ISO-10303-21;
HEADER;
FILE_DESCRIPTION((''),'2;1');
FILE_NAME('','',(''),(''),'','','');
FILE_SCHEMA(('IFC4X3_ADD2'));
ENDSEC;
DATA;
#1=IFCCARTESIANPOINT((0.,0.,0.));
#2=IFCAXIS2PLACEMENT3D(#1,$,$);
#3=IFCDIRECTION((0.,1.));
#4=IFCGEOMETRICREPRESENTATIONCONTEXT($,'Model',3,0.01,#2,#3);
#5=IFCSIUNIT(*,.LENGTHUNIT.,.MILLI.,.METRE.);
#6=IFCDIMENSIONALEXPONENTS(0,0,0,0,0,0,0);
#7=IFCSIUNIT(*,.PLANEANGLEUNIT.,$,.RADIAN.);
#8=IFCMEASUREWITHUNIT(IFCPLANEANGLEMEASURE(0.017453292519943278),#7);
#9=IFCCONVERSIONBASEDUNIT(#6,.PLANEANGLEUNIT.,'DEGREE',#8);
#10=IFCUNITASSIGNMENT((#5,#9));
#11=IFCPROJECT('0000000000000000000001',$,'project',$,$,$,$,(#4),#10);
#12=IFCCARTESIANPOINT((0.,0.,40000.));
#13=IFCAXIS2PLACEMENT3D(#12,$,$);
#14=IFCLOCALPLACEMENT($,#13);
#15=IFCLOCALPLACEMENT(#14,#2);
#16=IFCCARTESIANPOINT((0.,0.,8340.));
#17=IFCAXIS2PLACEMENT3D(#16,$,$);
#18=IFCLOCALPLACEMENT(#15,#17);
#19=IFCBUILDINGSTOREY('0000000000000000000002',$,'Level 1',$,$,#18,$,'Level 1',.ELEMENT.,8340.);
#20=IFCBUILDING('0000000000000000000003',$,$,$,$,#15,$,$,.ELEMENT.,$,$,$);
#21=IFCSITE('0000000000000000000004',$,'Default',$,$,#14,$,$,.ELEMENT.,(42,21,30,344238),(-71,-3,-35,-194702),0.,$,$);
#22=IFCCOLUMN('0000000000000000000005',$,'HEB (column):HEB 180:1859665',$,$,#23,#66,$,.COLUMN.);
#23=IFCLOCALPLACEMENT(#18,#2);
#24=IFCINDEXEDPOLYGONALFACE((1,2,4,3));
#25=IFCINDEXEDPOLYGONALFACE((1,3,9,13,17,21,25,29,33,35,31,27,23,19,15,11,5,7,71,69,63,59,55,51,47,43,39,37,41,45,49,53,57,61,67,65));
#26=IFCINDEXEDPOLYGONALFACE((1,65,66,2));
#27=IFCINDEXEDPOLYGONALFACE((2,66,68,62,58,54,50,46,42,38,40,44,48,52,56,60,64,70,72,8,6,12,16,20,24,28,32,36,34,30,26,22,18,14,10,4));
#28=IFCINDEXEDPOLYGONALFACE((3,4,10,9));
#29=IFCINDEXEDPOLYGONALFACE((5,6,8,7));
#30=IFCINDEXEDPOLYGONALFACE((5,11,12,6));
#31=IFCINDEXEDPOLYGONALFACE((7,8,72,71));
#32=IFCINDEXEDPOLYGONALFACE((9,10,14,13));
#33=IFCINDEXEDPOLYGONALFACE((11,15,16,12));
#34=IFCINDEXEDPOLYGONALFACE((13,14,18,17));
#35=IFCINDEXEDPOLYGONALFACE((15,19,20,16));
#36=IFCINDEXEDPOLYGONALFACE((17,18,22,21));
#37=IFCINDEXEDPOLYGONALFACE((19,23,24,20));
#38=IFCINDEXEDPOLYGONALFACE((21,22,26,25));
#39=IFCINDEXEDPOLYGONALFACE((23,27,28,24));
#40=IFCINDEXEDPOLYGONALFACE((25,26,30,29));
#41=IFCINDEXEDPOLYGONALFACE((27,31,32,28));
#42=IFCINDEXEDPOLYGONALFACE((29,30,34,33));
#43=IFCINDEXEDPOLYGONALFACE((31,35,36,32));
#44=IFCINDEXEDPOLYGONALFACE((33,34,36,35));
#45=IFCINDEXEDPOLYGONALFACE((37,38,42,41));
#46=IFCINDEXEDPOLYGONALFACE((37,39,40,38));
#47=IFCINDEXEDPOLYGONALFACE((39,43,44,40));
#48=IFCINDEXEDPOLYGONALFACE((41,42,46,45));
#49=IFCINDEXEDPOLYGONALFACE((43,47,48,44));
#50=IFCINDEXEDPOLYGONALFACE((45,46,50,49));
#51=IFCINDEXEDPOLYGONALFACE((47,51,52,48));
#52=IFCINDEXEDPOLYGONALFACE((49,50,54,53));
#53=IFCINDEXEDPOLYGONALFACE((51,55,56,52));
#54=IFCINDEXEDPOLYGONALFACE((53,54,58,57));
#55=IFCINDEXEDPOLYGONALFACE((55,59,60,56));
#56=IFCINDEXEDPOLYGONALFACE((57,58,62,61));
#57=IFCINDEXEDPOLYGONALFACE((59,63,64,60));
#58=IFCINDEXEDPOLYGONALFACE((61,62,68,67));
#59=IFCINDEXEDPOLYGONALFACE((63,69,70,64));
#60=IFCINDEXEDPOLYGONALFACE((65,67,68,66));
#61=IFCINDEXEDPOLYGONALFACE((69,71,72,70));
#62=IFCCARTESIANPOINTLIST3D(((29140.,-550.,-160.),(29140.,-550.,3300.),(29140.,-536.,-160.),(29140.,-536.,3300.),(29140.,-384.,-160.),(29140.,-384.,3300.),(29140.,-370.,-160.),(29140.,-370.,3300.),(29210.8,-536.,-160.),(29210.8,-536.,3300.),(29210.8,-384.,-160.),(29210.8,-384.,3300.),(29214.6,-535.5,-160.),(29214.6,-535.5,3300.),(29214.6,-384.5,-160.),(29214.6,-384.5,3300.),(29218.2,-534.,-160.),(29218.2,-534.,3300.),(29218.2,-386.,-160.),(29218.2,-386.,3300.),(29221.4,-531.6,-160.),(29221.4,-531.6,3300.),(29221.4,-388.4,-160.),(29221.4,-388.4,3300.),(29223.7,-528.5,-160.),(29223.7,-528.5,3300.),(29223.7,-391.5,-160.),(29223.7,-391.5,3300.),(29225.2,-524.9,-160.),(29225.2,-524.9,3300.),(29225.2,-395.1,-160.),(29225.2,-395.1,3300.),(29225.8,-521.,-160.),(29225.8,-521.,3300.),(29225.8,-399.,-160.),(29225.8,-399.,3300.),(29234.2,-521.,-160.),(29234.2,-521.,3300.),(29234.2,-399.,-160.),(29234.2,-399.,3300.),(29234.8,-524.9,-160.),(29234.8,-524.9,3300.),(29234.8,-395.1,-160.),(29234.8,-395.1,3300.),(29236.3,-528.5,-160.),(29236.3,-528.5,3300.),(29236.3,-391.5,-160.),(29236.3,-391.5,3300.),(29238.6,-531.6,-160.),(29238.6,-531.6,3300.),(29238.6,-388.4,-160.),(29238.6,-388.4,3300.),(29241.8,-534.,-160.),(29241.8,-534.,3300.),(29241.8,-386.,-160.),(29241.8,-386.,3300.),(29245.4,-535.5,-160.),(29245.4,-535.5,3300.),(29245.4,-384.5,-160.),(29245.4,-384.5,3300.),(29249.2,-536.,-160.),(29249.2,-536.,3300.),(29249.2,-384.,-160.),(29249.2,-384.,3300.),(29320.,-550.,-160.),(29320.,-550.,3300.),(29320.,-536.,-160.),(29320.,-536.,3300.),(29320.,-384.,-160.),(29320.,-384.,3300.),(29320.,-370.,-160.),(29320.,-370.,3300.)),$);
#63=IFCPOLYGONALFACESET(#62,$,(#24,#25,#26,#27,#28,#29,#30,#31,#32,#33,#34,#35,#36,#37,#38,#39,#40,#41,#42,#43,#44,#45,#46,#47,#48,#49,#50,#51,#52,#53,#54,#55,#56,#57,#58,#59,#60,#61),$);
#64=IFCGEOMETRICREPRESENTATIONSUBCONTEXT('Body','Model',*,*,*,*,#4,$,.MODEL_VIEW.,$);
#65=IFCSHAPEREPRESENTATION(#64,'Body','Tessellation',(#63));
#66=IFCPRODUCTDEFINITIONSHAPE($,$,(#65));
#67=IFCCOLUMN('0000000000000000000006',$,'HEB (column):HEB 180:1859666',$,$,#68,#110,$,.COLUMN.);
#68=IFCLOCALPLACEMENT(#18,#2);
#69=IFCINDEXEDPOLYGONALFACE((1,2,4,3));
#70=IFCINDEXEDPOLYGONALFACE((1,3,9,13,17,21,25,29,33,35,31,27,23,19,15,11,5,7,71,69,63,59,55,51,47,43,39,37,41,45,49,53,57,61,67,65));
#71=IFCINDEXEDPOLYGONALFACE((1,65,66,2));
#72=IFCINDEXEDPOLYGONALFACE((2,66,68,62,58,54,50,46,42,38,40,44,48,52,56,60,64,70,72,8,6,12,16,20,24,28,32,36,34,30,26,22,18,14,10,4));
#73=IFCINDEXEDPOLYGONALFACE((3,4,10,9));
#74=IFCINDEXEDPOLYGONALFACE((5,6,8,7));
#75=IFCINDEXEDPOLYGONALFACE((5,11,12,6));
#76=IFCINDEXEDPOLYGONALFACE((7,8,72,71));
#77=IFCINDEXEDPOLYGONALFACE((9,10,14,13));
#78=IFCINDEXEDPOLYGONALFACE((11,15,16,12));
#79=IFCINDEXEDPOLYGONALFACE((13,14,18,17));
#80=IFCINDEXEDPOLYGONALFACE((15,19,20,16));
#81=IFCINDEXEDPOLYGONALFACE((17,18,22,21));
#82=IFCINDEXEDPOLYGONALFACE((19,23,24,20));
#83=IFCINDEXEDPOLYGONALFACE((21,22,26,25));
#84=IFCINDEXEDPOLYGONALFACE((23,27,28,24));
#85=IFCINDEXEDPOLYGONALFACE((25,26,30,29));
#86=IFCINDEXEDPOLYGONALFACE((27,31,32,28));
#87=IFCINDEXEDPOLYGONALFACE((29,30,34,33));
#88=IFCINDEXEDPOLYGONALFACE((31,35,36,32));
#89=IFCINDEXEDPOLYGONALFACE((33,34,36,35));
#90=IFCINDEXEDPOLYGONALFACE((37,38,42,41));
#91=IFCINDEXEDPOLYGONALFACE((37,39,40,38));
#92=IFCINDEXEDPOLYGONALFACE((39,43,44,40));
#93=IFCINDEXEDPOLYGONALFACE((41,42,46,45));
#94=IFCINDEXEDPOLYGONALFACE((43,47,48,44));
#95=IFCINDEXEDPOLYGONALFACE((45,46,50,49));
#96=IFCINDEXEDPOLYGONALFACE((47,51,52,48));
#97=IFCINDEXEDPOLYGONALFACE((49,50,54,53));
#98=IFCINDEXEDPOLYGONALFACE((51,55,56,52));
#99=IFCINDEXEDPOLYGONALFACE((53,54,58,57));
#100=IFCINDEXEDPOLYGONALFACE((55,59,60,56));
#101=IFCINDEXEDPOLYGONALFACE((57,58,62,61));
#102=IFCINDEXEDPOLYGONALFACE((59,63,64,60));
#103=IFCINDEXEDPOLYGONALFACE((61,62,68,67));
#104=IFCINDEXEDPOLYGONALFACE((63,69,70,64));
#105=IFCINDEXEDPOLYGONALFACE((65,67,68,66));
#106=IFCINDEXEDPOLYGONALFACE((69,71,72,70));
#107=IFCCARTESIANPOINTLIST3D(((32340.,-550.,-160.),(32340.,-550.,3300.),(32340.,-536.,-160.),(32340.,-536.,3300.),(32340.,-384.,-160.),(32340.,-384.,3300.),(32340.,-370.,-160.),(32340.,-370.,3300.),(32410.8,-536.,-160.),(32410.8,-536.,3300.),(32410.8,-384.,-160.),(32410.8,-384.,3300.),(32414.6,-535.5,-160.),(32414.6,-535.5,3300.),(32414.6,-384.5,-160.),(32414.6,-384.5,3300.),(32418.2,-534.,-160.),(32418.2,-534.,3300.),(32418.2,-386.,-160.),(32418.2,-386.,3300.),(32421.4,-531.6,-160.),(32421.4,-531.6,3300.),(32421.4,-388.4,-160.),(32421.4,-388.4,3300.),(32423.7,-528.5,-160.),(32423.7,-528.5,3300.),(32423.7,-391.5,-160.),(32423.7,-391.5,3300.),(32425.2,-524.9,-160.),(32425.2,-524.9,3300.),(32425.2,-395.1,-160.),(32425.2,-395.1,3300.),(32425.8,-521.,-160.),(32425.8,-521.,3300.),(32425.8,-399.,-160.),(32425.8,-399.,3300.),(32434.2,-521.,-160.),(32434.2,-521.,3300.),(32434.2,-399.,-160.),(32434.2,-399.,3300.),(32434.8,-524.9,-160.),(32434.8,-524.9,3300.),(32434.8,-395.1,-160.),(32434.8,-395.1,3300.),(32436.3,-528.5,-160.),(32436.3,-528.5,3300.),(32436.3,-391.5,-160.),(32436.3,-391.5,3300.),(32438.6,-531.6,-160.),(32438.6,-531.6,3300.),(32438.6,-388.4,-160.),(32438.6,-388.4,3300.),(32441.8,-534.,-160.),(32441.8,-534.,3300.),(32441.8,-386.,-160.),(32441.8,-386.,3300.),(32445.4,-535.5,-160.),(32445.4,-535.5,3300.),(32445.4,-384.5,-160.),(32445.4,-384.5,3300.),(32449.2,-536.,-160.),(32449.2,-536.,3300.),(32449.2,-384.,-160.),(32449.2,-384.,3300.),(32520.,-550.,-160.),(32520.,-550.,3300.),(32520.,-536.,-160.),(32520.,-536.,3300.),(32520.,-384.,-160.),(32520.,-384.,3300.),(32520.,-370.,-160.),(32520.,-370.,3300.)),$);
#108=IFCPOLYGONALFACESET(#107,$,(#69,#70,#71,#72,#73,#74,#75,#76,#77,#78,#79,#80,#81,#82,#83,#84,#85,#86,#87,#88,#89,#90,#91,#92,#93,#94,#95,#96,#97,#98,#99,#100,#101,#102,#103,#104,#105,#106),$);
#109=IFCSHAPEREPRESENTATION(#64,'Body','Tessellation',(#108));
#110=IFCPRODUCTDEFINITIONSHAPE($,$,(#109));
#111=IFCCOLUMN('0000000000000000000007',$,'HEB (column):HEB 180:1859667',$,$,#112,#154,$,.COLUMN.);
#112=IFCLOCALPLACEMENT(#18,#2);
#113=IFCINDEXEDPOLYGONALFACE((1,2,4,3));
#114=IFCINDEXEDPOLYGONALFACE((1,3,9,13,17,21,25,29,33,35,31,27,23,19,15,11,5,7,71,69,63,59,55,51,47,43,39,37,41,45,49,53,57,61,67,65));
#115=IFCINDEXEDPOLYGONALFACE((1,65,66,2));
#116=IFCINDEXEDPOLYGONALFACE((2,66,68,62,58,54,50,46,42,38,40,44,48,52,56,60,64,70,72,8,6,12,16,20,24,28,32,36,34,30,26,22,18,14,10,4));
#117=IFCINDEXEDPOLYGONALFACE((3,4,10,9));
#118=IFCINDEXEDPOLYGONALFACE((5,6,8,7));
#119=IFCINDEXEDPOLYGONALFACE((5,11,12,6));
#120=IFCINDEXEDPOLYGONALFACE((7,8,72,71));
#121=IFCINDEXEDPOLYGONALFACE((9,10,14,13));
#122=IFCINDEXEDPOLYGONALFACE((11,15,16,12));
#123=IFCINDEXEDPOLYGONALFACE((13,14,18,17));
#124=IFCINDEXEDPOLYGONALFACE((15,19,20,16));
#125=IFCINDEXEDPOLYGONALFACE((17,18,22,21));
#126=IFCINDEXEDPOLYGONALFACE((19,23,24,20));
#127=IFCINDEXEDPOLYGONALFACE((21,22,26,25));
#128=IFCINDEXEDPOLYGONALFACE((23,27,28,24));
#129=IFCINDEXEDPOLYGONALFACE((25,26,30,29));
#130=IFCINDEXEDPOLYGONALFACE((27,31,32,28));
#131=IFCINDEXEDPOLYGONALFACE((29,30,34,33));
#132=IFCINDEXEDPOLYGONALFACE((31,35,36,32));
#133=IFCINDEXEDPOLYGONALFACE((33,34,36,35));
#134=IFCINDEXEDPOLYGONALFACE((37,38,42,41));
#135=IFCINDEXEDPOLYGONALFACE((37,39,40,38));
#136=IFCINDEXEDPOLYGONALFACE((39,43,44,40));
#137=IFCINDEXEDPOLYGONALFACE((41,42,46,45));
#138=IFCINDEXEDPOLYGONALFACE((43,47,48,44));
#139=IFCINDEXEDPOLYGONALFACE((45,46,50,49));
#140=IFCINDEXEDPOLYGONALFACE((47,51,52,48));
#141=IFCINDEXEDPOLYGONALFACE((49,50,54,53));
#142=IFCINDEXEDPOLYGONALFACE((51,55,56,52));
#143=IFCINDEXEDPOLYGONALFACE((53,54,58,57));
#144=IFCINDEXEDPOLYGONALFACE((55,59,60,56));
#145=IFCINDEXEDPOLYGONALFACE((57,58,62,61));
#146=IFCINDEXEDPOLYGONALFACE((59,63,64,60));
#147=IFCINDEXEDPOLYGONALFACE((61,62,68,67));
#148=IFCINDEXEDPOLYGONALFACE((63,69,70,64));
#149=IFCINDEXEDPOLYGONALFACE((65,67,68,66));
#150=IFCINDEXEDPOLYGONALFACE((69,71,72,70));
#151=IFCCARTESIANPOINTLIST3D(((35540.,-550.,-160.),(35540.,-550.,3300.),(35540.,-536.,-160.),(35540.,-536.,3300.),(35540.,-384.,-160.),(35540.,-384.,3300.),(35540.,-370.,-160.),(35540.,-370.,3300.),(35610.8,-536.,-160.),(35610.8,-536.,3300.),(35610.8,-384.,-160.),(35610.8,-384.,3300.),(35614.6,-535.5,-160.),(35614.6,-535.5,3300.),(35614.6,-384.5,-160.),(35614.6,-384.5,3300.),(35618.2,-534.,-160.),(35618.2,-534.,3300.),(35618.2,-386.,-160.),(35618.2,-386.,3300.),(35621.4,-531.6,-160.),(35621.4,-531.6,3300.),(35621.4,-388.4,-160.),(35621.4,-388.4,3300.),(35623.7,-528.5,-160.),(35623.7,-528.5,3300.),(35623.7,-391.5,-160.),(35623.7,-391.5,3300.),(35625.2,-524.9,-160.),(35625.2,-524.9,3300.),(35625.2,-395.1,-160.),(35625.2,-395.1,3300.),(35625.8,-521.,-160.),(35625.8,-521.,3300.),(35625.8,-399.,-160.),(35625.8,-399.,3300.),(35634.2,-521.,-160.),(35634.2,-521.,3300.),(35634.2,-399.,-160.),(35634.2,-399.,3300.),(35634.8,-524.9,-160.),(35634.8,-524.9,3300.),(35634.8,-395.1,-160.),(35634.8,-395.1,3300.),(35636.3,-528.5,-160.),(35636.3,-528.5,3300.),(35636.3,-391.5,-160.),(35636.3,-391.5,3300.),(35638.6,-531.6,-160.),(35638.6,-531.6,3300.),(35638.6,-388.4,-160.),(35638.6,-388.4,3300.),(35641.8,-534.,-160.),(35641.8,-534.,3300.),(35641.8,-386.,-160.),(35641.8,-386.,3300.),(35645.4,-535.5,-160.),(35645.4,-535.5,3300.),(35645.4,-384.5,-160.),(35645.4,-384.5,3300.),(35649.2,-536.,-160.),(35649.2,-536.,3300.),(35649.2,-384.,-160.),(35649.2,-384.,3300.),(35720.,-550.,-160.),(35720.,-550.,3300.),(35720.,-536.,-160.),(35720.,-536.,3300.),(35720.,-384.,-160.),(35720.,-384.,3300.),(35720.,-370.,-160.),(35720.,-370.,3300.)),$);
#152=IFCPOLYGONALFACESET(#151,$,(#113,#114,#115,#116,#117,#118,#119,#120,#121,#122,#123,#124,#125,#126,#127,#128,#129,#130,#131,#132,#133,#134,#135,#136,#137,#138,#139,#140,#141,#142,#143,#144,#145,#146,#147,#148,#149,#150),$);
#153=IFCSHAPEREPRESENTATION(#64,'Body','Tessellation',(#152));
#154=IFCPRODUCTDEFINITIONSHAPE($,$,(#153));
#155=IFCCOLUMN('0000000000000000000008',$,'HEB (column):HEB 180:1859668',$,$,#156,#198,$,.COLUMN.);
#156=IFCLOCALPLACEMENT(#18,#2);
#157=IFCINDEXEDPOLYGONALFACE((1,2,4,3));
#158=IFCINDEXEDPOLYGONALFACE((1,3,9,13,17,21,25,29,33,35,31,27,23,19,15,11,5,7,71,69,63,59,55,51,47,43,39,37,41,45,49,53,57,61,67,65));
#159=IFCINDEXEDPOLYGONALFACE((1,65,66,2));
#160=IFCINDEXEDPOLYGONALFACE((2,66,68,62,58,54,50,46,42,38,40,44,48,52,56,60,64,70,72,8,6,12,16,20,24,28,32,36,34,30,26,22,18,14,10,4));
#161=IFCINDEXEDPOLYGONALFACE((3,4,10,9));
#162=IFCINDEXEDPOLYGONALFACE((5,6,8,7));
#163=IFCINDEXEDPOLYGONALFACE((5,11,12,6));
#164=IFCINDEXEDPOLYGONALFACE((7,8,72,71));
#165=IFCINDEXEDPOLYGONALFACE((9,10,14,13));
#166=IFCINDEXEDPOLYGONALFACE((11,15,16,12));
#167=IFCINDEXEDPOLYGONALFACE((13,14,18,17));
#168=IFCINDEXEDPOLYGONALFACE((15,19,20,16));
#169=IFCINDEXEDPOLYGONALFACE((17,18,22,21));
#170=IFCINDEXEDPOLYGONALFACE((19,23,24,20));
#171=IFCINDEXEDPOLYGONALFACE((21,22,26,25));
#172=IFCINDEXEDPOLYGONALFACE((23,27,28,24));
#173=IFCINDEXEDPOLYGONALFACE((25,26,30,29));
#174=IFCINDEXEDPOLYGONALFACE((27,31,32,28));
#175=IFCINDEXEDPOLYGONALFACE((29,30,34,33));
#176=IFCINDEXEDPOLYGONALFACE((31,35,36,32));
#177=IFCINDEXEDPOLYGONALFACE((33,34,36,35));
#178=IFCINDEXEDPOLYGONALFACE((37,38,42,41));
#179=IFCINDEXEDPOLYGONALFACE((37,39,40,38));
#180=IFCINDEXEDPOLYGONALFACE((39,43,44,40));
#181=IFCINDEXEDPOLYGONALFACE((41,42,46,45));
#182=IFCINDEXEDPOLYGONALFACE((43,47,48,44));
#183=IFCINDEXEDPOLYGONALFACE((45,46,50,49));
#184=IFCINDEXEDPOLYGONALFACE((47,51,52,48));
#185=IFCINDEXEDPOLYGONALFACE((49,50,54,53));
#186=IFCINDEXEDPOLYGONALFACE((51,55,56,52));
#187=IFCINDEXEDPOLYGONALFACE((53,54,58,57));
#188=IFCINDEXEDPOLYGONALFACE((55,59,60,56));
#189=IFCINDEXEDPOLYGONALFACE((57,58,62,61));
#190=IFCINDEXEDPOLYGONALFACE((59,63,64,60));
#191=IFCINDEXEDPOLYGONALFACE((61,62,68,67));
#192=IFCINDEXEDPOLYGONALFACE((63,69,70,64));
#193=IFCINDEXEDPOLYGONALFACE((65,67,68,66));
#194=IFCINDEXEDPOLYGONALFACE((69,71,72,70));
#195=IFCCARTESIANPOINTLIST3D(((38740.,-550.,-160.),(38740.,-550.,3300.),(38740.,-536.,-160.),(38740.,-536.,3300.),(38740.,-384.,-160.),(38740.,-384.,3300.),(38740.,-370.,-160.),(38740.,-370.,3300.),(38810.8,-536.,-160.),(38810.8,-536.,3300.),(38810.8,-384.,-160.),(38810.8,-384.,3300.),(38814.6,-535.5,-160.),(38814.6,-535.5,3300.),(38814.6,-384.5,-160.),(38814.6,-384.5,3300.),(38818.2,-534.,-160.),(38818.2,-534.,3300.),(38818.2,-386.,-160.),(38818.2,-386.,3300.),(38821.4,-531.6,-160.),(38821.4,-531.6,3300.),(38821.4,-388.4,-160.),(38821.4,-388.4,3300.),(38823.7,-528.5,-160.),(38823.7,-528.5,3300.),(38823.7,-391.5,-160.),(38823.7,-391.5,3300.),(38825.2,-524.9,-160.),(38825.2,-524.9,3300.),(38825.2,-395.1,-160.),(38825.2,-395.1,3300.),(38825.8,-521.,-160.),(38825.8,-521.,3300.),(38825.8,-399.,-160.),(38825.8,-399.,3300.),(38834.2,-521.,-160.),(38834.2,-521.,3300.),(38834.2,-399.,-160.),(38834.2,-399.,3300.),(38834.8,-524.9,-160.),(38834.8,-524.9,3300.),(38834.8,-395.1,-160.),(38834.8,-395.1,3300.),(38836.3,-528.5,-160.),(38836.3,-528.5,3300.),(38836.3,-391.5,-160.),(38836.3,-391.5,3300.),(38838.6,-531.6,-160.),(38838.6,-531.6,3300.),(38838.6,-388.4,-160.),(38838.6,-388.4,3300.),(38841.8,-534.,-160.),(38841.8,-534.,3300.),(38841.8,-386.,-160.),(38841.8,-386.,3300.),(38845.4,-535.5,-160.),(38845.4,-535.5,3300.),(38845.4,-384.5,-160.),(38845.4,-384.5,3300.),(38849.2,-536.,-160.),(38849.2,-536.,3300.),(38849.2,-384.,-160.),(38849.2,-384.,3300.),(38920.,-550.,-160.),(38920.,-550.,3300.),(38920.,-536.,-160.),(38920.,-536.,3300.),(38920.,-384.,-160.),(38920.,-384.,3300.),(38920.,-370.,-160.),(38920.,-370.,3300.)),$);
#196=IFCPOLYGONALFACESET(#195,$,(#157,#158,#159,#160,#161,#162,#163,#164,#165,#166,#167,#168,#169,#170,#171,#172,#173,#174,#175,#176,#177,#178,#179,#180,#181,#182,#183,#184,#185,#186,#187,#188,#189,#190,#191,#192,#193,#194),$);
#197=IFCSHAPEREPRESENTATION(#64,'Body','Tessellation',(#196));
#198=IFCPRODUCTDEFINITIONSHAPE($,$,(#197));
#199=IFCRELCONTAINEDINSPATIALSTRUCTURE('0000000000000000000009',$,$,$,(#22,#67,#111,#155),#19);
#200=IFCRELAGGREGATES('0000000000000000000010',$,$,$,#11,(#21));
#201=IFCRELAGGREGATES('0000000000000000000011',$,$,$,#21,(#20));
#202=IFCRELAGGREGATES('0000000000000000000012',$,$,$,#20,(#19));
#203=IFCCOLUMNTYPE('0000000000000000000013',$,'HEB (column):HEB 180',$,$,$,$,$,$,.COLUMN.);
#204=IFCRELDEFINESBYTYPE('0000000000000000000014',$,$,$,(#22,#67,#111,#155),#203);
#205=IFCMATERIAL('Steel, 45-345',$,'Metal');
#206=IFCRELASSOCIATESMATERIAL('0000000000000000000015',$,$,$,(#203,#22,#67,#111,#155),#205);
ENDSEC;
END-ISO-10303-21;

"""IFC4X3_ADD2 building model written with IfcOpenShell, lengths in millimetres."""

from ifc_helpers import new_model, entity, si_unit, converted_unit, direction, frame, origin, origin_2d_with_axis, place, context, subcontext, project, spatial, i_section, extrude, source, transform, mapped, material, material_profile, profile_set, profile_usage, type_object, type_shapes, element, save


model = new_model("IFC4X3_ADD2")

# Units and contexts
model_context = context("Model", 3, precision=0.01, world=origin(), true_north=direction((0.0, 1.0)))
body_context = subcontext(model_context, "Body", "Model", "MODEL_VIEW")
ifc_project = project(units=[si_unit("LENGTHUNIT", "METRE", prefix="MILLI"), converted_unit("PLANEANGLEUNIT", "DEGREE", entity("IfcPlaneAngleMeasure", 0.017453292519943278), si_unit("PLANEANGLEUNIT", "RADIAN"), dimensions=[0, 0, 0, 0, 0, 0, 0])], contexts=[model_context])

# Site, building, storey
site_placement = place(None, frame((0.0, 0.0, 40000.0)))
site = spatial("IfcSite", under=ifc_project, at=site_placement, Name="Default", CompositionType="ELEMENT", RefLatitude=(42, 21, 30, 344238), RefLongitude=(-71, -3, -35, -194702), RefElevation=0.0)
building_placement = place(site_placement, origin())
building = spatial("IfcBuilding", under=site, at=building_placement, CompositionType="ELEMENT")
storey_placement = place(building_placement, frame((0.0, 0.0, 8340.0)))
storey = spatial("IfcBuildingStorey", under=building, at=storey_placement, Name="Level 1", LongName="Level 1", CompositionType="ELEMENT", Elevation=8340.0)

# Columns
ifc_material = material(Name="Steel, 45-345", Category="Metal")
ifc_material_profile_1 = material_profile(ifc_material, i_section(OverallWidth=180.0, OverallDepth=180.0, WebThickness=8.5, FlangeThickness=14.0, FilletRadius=15.0, at=origin_2d_with_axis()), Name="HEB 180")
ifc_profile_set_1 = profile_set([ifc_material_profile_1], Name="HEB 180")
ifc_profile_usage_1 = profile_usage(ifc_profile_set_1)
column_type_1 = type_object("IfcColumnType", Name="HEB (column):HEB 180", PredefinedType="COLUMN", material=ifc_profile_set_1)
shared_shape_1 = source(origin(), body_context, "Body", "SweptSolid", [
    extrude(i_section(OverallWidth=180.0, OverallDepth=180.0, WebThickness=8.5, FlangeThickness=14.0, FilletRadius=15.0, at=origin_2d_with_axis()), frame((0.0, 0.0, 8180.0), z_axis=(0.0, 0.0, 1.0), x_axis=(-1.0, 0.0, 0.0)), (0.0, 0.0, 1.0), 3460.0),
])
type_shapes(column_type_1, [shared_shape_1])
for number, where, name in (
    (1, (29230.0, -460.0, -8340.0), "HEB (column):HEB 180:1859665"),
    (2, (32430.0, -460.0, -8340.0), "HEB (column):HEB 180:1859666"),
    (3, (35630.0, -460.0, -8340.0), "HEB (column):HEB 180:1859667"),
    (4, (38830.0, -460.0, -8340.0), "HEB (column):HEB 180:1859668"),
):
    element("IfcColumn", number, at=place(storey_placement, frame(where)), inside=storey, type_object=column_type_1, material=ifc_profile_usage_1, Name=name, PredefinedType="COLUMN", context=body_context, shape_type="MappedRepresentation", body=[
        mapped(shared_shape_1, transform((0.0, 0.0, 0.0), scale=1.0)),
    ])

save(model, "model.ifc")
